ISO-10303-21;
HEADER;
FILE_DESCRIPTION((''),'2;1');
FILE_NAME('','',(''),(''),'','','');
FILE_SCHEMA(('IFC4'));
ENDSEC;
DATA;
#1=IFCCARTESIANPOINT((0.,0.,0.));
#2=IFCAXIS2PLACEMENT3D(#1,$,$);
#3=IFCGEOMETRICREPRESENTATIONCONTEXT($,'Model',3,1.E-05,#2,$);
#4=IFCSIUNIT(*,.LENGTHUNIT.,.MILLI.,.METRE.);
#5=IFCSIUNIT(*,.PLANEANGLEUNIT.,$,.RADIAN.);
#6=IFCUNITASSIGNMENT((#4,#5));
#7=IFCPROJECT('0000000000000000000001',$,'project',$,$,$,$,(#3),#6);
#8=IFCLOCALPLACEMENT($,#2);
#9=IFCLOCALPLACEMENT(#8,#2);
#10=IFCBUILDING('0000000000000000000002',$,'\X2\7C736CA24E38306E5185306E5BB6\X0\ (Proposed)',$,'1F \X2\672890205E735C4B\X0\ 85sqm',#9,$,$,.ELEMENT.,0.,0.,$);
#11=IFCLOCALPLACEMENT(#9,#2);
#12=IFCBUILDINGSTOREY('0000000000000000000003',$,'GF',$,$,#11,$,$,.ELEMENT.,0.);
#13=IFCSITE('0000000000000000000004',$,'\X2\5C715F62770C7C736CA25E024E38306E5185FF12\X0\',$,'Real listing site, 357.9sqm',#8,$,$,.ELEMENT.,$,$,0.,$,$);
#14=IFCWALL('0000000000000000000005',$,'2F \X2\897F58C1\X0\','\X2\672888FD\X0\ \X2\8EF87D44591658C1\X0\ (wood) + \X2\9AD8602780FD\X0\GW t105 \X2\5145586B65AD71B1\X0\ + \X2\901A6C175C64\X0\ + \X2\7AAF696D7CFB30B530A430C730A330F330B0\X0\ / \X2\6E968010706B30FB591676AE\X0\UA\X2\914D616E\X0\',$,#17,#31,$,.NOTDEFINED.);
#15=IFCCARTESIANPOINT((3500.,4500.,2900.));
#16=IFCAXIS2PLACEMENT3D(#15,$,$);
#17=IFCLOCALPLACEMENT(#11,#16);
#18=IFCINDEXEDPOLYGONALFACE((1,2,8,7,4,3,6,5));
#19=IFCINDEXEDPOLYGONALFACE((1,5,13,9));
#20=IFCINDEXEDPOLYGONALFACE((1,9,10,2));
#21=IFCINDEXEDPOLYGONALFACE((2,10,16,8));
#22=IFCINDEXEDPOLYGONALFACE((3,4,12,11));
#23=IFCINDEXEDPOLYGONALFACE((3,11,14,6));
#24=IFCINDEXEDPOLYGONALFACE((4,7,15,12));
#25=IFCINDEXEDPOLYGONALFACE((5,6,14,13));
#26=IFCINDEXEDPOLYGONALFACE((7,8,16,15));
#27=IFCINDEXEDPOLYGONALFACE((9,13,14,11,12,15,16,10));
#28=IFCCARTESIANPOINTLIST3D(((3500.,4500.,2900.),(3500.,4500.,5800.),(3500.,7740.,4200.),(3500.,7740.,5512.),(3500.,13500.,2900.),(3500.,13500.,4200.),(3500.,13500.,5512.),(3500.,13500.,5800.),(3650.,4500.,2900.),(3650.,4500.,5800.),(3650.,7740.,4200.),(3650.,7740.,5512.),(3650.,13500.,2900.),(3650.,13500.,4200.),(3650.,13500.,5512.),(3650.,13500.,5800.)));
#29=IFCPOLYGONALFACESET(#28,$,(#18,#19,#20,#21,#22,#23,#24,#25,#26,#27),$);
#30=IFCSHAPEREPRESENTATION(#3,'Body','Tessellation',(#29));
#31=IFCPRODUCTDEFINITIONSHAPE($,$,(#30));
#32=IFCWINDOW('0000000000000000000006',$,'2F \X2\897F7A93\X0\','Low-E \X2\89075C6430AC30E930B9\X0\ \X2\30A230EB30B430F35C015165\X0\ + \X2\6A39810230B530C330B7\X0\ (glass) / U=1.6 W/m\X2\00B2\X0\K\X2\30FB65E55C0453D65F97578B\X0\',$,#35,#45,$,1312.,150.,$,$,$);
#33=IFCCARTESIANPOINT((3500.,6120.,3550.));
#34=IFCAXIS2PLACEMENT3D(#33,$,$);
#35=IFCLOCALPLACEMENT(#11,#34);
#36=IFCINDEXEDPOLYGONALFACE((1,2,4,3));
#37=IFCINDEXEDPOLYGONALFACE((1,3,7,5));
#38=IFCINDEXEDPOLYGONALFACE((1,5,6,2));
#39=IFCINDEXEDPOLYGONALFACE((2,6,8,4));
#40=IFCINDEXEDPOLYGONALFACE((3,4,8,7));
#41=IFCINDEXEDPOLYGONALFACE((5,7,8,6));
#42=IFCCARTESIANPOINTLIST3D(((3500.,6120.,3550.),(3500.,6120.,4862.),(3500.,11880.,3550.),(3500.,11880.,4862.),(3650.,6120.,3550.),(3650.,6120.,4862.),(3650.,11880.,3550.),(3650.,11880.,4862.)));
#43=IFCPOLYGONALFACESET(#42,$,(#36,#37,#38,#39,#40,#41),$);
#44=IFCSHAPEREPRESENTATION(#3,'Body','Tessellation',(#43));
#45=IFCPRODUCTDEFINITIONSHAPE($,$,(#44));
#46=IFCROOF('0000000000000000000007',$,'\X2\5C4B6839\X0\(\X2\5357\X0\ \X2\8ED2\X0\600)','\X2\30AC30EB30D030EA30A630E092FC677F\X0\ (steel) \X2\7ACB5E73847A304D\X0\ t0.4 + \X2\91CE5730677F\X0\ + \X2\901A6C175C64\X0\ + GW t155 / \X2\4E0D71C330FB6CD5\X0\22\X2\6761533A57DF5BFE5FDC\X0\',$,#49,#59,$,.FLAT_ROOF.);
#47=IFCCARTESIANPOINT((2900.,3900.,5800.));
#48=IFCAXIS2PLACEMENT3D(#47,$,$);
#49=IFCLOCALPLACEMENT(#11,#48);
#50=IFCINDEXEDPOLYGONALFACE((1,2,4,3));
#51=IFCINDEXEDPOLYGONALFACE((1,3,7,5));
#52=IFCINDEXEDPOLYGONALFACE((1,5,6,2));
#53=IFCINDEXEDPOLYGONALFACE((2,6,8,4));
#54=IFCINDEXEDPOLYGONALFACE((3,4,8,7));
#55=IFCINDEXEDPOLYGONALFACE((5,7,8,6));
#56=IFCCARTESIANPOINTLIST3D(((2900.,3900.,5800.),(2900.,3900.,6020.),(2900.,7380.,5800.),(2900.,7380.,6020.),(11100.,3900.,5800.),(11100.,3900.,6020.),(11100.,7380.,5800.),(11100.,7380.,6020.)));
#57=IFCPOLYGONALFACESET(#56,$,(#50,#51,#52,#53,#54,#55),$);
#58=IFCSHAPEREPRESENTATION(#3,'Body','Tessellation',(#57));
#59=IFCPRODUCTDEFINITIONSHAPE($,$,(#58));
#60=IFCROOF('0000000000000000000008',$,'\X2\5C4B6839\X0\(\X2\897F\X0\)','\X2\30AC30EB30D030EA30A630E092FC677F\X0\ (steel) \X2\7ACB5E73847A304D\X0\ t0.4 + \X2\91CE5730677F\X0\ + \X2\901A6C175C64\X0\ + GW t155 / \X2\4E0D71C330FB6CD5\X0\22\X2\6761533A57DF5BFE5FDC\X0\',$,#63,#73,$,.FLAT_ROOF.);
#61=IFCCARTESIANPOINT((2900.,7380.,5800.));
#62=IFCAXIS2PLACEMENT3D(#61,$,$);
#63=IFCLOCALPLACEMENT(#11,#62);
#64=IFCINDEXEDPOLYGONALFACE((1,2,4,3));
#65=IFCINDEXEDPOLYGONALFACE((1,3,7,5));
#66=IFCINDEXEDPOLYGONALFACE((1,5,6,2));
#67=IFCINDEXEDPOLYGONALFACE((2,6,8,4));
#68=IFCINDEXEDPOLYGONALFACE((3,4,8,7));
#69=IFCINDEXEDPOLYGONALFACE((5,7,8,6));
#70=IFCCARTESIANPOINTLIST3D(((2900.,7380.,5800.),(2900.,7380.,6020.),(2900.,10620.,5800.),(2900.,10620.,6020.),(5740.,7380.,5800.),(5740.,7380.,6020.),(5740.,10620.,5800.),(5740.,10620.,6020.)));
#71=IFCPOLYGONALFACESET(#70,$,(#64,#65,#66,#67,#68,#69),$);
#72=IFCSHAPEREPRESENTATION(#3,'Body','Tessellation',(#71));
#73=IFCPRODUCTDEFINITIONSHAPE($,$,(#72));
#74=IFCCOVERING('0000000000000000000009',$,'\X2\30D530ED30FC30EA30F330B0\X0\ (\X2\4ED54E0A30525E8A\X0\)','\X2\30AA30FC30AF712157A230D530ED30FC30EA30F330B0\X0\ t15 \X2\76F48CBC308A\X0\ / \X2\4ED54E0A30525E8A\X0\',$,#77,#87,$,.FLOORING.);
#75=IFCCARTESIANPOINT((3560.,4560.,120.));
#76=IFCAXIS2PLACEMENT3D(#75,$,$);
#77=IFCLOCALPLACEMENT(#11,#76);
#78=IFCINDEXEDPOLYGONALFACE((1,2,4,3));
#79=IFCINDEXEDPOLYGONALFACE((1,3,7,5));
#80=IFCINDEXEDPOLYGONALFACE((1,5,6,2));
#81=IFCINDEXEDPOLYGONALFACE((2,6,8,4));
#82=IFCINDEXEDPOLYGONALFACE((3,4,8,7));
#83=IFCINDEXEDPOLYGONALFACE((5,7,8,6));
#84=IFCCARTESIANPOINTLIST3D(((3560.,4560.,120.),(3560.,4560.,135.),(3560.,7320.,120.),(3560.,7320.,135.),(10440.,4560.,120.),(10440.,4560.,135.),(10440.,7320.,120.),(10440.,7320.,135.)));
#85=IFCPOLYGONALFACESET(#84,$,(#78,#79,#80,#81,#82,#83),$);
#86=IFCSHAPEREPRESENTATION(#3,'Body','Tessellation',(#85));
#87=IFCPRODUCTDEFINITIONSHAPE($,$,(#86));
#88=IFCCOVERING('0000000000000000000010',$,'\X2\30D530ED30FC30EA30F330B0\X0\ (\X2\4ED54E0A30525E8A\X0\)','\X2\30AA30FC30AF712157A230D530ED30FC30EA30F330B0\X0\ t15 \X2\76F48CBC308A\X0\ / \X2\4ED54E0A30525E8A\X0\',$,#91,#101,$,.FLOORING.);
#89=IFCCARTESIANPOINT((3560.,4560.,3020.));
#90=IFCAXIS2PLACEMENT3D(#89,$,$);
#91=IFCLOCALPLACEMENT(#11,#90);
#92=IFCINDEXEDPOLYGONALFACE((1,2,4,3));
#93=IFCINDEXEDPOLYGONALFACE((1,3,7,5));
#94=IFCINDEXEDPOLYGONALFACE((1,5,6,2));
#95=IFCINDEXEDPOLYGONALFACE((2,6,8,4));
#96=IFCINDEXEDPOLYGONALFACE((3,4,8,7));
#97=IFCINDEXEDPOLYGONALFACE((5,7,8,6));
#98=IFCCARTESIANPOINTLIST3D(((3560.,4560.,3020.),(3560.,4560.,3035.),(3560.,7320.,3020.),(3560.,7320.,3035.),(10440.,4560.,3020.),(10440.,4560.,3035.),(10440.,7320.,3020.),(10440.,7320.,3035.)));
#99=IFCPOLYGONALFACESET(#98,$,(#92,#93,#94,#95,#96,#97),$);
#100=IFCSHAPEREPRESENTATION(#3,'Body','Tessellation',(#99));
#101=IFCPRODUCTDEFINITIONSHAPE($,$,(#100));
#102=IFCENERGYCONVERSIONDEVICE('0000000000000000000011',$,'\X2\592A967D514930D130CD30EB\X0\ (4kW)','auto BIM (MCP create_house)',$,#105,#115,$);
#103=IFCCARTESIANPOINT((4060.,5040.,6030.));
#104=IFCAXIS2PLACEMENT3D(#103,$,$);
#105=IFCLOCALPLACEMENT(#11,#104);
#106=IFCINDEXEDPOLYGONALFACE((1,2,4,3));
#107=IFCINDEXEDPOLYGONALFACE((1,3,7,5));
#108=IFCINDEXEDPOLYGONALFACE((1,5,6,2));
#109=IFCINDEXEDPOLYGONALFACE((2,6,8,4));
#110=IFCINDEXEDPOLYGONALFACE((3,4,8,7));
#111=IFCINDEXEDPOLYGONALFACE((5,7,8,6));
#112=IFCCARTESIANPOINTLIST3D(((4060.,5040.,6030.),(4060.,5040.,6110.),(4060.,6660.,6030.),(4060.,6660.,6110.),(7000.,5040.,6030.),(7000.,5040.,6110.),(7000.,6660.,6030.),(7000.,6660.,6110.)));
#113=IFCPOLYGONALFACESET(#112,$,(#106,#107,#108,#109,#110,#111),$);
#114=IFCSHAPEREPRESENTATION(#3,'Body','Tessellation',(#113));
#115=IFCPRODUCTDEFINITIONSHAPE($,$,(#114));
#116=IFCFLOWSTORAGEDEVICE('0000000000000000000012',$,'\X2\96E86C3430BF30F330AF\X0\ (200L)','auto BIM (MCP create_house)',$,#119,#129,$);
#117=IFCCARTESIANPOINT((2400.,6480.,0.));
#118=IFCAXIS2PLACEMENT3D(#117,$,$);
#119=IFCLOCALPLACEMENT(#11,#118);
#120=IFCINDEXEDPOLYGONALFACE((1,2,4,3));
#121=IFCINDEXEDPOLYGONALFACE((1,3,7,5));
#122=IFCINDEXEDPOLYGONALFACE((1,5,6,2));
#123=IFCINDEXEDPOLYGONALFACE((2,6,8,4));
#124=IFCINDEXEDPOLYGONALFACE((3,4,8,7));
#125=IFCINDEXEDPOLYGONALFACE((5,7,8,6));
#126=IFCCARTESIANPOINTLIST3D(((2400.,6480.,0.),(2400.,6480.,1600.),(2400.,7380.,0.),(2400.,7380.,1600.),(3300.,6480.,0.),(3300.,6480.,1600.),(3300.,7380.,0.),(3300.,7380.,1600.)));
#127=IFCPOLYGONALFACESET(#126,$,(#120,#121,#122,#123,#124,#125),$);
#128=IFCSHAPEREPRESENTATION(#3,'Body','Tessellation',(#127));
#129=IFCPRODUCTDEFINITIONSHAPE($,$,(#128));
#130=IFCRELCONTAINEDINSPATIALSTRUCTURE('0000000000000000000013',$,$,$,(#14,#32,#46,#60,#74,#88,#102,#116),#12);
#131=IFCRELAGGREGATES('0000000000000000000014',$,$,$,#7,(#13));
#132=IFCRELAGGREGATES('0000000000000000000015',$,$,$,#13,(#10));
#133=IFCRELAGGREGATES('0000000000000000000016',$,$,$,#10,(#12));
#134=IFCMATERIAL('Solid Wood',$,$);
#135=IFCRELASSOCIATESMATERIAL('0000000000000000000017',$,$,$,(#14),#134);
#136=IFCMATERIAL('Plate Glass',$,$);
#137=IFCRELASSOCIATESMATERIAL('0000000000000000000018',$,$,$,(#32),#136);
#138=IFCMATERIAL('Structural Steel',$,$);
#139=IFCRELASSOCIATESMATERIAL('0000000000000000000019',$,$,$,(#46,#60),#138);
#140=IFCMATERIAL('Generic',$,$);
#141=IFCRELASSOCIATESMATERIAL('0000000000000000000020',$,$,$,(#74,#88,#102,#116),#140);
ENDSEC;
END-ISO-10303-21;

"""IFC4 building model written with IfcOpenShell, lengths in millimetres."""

from ifc_helpers import new_model, si_unit, frame, frame_2d, origin, place, context, project, spatial, rectangle, extrude, material, element, fill, save


model = new_model("IFC4")

# Units and contexts
model_context = context("Model", 3, precision=1e-05, world=origin())
ifc_project = project(units=[si_unit("LENGTHUNIT", "METRE", prefix="MILLI"), si_unit("PLANEANGLEUNIT", "RADIAN")], contexts=[model_context])

# Site, building, storey
site_placement = place(None, origin())
site = spatial("IfcSite", under=ifc_project, at=site_placement, Name="山形県米沢市丸の内２", ObjectType="Real listing site, 357.9sqm", CompositionType="ELEMENT", RefElevation=0.0)
building_placement = place(site_placement, origin())
building = spatial("IfcBuilding", under=site, at=building_placement, Name="米沢丸の内の家 (Proposed)", ObjectType="1F 木造平屋 85sqm", CompositionType="ELEMENT", ElevationOfRefHeight=0.0, ElevationOfTerrain=0.0)
storey_placement = place(building_placement, origin())
storey = spatial("IfcBuildingStorey", under=building, at=storey_placement, Name="GF", CompositionType="ELEMENT", Elevation=0.0)

# Shared definitions
ifc_material_1 = material(Name="Solid Wood")
ifc_material_2 = material(Name="Generic")

# Shared definitions
ifc_material_3 = material(Name="Plate Glass")

# Wall, opening, window
wall_1_placement = place(storey_placement, frame((3500.0, 4500.0, 2900.0)))
wall_1 = element("IfcWall", 1, at=wall_1_placement, inside=storey, material=ifc_material_1, Name="2F 西壁", Description="木製 軸組外壁 (wood) + 高性能GW t105 充填断熱 + 通気層 + 窯業系サイディング / 準耐火・外皮UA配慮", PredefinedType="NOTDEFINED", context=model_context, shape_type="SweptSolid", body=[
    extrude(rectangle(XDim=150.0, YDim=9000.0, at=frame_2d((75.0, 4500.0))), frame((3500.0, 4500.0, 2900.0)), (0.0, 0.0, 1.0), 2900.0),
])
opening_1_placement = place(storey_placement, frame((3500.0, 6120.0, 3550.0)))
opening_1 = element("IfcOpeningElement", 2, at=opening_1_placement, cuts=wall_1, PredefinedType="NOTDEFINED", context=model_context, shape_type="SweptSolid", body=[
    extrude(rectangle(XDim=150.0, YDim=5760.0, at=frame_2d((75.0, 2880.0))), frame((3500.0, 6120.0, 3550.0)), (0.0, 0.0, 1.0), 1312.0),
])
window_1_placement = place(storey_placement, frame((3500.0, 6120.0, 3550.0)))
window_1 = element("IfcWindow", 3, at=window_1_placement, inside=storey, material=ifc_material_3, Name="2F 西窓", Description="Low-E 複層ガラス アルゴン封入 + 樹脂サッシ (glass) / U=1.6 W/m²K・日射取得型", OverallHeight=1312.0, OverallWidth=150.0, context=model_context, shape_type="SweptSolid", body=[
    extrude(rectangle(XDim=150.0, YDim=5760.0, at=frame_2d((75.0, 2880.0))), frame((3500.0, 6120.0, 3550.0)), (0.0, 0.0, 1.0), 1312.0),
])
fill(opening_1, window_1)

# Roofs
ifc_material_4 = material(Name="Structural Steel")
roof_1_placement = place(storey_placement, frame((2900.0, 3900.0, 5800.0)))
element("IfcRoof", 4, at=roof_1_placement, inside=storey, material=ifc_material_4, Name="屋根(南 軒600)", Description="ガルバリウム鋼板 (steel) 立平葺き t0.4 + 野地板 + 通気層 + GW t155 / 不燃・法22条区域対応", PredefinedType="FLAT_ROOF", context=model_context, shape_type="SweptSolid", body=[
    extrude(rectangle(XDim=8200.0, YDim=3480.0, at=frame_2d((4100.0, 1740.0))), frame((2900.0, 3900.0, 5800.0)), (0.0, 0.0, 1.0), 220.0),
])
roof_2_placement = place(storey_placement, frame((2900.0, 7380.0, 5800.0)))
element("IfcRoof", 5, at=roof_2_placement, inside=storey, material=ifc_material_4, Name="屋根(西)", Description="ガルバリウム鋼板 (steel) 立平葺き t0.4 + 野地板 + 通気層 + GW t155 / 不燃・法22条区域対応", PredefinedType="FLAT_ROOF", context=model_context, shape_type="SweptSolid", body=[
    extrude(rectangle(XDim=2840.0, YDim=3240.0, at=frame_2d((1420.0, 1620.0))), frame((2900.0, 7380.0, 5800.0)), (0.0, 0.0, 1.0), 220.0),
])

# Coverings
covering_1_placement = place(storey_placement, frame((3560.0, 4560.0, 120.0)))
element("IfcCovering", 6, at=covering_1_placement, inside=storey, material=ifc_material_2, Name="フローリング (仕上げ床)", Description="オーク無垢フローリング t15 直貼り / 仕上げ床", PredefinedType="FLOORING", context=model_context, shape_type="SweptSolid", body=[
    extrude(rectangle(XDim=6880.0, YDim=2760.0, at=frame_2d((3440.0, 1380.0))), frame((3560.0, 4560.0, 120.0)), (0.0, 0.0, 1.0), 15.0),
])
covering_2_placement = place(storey_placement, frame((3560.0, 4560.0, 3020.0)))
element("IfcCovering", 7, at=covering_2_placement, inside=storey, material=ifc_material_2, Name="フローリング (仕上げ床)", Description="オーク無垢フローリング t15 直貼り / 仕上げ床", PredefinedType="FLOORING", context=model_context, shape_type="SweptSolid", body=[
    extrude(rectangle(XDim=6880.0, YDim=2760.0, at=frame_2d((3440.0, 1380.0))), frame((3560.0, 4560.0, 3020.0)), (0.0, 0.0, 1.0), 15.0),
])

# Energy conversion device
energy_conversion_device_placement = place(storey_placement, frame((4060.0, 5040.0, 6030.0)))
element("IfcEnergyConversionDevice", 8, at=energy_conversion_device_placement, inside=storey, material=ifc_material_2, Name="太陽光パネル (4kW)", Description="auto BIM (MCP create_house)", context=model_context, shape_type="SweptSolid", body=[
    extrude(rectangle(XDim=2940.0, YDim=1620.0, at=frame_2d((1470.0, 810.0))), frame((4060.0, 5040.0, 6030.0)), (0.0, 0.0, 1.0), 80.0),
])

# Flow storage device
flow_storage_device_placement = place(storey_placement, frame((2400.0, 6480.0, 0.0)))
element("IfcFlowStorageDevice", 9, at=flow_storage_device_placement, inside=storey, material=ifc_material_2, Name="雨水タンク (200L)", Description="auto BIM (MCP create_house)", context=model_context, shape_type="SweptSolid", body=[
    extrude(rectangle(XDim=900.0, YDim=900.0, at=frame_2d((450.0, 450.0))), frame((2400.0, 6480.0, 0.0)), (0.0, 0.0, 1.0), 1600.0),
])

save(model, "model.ifc")
